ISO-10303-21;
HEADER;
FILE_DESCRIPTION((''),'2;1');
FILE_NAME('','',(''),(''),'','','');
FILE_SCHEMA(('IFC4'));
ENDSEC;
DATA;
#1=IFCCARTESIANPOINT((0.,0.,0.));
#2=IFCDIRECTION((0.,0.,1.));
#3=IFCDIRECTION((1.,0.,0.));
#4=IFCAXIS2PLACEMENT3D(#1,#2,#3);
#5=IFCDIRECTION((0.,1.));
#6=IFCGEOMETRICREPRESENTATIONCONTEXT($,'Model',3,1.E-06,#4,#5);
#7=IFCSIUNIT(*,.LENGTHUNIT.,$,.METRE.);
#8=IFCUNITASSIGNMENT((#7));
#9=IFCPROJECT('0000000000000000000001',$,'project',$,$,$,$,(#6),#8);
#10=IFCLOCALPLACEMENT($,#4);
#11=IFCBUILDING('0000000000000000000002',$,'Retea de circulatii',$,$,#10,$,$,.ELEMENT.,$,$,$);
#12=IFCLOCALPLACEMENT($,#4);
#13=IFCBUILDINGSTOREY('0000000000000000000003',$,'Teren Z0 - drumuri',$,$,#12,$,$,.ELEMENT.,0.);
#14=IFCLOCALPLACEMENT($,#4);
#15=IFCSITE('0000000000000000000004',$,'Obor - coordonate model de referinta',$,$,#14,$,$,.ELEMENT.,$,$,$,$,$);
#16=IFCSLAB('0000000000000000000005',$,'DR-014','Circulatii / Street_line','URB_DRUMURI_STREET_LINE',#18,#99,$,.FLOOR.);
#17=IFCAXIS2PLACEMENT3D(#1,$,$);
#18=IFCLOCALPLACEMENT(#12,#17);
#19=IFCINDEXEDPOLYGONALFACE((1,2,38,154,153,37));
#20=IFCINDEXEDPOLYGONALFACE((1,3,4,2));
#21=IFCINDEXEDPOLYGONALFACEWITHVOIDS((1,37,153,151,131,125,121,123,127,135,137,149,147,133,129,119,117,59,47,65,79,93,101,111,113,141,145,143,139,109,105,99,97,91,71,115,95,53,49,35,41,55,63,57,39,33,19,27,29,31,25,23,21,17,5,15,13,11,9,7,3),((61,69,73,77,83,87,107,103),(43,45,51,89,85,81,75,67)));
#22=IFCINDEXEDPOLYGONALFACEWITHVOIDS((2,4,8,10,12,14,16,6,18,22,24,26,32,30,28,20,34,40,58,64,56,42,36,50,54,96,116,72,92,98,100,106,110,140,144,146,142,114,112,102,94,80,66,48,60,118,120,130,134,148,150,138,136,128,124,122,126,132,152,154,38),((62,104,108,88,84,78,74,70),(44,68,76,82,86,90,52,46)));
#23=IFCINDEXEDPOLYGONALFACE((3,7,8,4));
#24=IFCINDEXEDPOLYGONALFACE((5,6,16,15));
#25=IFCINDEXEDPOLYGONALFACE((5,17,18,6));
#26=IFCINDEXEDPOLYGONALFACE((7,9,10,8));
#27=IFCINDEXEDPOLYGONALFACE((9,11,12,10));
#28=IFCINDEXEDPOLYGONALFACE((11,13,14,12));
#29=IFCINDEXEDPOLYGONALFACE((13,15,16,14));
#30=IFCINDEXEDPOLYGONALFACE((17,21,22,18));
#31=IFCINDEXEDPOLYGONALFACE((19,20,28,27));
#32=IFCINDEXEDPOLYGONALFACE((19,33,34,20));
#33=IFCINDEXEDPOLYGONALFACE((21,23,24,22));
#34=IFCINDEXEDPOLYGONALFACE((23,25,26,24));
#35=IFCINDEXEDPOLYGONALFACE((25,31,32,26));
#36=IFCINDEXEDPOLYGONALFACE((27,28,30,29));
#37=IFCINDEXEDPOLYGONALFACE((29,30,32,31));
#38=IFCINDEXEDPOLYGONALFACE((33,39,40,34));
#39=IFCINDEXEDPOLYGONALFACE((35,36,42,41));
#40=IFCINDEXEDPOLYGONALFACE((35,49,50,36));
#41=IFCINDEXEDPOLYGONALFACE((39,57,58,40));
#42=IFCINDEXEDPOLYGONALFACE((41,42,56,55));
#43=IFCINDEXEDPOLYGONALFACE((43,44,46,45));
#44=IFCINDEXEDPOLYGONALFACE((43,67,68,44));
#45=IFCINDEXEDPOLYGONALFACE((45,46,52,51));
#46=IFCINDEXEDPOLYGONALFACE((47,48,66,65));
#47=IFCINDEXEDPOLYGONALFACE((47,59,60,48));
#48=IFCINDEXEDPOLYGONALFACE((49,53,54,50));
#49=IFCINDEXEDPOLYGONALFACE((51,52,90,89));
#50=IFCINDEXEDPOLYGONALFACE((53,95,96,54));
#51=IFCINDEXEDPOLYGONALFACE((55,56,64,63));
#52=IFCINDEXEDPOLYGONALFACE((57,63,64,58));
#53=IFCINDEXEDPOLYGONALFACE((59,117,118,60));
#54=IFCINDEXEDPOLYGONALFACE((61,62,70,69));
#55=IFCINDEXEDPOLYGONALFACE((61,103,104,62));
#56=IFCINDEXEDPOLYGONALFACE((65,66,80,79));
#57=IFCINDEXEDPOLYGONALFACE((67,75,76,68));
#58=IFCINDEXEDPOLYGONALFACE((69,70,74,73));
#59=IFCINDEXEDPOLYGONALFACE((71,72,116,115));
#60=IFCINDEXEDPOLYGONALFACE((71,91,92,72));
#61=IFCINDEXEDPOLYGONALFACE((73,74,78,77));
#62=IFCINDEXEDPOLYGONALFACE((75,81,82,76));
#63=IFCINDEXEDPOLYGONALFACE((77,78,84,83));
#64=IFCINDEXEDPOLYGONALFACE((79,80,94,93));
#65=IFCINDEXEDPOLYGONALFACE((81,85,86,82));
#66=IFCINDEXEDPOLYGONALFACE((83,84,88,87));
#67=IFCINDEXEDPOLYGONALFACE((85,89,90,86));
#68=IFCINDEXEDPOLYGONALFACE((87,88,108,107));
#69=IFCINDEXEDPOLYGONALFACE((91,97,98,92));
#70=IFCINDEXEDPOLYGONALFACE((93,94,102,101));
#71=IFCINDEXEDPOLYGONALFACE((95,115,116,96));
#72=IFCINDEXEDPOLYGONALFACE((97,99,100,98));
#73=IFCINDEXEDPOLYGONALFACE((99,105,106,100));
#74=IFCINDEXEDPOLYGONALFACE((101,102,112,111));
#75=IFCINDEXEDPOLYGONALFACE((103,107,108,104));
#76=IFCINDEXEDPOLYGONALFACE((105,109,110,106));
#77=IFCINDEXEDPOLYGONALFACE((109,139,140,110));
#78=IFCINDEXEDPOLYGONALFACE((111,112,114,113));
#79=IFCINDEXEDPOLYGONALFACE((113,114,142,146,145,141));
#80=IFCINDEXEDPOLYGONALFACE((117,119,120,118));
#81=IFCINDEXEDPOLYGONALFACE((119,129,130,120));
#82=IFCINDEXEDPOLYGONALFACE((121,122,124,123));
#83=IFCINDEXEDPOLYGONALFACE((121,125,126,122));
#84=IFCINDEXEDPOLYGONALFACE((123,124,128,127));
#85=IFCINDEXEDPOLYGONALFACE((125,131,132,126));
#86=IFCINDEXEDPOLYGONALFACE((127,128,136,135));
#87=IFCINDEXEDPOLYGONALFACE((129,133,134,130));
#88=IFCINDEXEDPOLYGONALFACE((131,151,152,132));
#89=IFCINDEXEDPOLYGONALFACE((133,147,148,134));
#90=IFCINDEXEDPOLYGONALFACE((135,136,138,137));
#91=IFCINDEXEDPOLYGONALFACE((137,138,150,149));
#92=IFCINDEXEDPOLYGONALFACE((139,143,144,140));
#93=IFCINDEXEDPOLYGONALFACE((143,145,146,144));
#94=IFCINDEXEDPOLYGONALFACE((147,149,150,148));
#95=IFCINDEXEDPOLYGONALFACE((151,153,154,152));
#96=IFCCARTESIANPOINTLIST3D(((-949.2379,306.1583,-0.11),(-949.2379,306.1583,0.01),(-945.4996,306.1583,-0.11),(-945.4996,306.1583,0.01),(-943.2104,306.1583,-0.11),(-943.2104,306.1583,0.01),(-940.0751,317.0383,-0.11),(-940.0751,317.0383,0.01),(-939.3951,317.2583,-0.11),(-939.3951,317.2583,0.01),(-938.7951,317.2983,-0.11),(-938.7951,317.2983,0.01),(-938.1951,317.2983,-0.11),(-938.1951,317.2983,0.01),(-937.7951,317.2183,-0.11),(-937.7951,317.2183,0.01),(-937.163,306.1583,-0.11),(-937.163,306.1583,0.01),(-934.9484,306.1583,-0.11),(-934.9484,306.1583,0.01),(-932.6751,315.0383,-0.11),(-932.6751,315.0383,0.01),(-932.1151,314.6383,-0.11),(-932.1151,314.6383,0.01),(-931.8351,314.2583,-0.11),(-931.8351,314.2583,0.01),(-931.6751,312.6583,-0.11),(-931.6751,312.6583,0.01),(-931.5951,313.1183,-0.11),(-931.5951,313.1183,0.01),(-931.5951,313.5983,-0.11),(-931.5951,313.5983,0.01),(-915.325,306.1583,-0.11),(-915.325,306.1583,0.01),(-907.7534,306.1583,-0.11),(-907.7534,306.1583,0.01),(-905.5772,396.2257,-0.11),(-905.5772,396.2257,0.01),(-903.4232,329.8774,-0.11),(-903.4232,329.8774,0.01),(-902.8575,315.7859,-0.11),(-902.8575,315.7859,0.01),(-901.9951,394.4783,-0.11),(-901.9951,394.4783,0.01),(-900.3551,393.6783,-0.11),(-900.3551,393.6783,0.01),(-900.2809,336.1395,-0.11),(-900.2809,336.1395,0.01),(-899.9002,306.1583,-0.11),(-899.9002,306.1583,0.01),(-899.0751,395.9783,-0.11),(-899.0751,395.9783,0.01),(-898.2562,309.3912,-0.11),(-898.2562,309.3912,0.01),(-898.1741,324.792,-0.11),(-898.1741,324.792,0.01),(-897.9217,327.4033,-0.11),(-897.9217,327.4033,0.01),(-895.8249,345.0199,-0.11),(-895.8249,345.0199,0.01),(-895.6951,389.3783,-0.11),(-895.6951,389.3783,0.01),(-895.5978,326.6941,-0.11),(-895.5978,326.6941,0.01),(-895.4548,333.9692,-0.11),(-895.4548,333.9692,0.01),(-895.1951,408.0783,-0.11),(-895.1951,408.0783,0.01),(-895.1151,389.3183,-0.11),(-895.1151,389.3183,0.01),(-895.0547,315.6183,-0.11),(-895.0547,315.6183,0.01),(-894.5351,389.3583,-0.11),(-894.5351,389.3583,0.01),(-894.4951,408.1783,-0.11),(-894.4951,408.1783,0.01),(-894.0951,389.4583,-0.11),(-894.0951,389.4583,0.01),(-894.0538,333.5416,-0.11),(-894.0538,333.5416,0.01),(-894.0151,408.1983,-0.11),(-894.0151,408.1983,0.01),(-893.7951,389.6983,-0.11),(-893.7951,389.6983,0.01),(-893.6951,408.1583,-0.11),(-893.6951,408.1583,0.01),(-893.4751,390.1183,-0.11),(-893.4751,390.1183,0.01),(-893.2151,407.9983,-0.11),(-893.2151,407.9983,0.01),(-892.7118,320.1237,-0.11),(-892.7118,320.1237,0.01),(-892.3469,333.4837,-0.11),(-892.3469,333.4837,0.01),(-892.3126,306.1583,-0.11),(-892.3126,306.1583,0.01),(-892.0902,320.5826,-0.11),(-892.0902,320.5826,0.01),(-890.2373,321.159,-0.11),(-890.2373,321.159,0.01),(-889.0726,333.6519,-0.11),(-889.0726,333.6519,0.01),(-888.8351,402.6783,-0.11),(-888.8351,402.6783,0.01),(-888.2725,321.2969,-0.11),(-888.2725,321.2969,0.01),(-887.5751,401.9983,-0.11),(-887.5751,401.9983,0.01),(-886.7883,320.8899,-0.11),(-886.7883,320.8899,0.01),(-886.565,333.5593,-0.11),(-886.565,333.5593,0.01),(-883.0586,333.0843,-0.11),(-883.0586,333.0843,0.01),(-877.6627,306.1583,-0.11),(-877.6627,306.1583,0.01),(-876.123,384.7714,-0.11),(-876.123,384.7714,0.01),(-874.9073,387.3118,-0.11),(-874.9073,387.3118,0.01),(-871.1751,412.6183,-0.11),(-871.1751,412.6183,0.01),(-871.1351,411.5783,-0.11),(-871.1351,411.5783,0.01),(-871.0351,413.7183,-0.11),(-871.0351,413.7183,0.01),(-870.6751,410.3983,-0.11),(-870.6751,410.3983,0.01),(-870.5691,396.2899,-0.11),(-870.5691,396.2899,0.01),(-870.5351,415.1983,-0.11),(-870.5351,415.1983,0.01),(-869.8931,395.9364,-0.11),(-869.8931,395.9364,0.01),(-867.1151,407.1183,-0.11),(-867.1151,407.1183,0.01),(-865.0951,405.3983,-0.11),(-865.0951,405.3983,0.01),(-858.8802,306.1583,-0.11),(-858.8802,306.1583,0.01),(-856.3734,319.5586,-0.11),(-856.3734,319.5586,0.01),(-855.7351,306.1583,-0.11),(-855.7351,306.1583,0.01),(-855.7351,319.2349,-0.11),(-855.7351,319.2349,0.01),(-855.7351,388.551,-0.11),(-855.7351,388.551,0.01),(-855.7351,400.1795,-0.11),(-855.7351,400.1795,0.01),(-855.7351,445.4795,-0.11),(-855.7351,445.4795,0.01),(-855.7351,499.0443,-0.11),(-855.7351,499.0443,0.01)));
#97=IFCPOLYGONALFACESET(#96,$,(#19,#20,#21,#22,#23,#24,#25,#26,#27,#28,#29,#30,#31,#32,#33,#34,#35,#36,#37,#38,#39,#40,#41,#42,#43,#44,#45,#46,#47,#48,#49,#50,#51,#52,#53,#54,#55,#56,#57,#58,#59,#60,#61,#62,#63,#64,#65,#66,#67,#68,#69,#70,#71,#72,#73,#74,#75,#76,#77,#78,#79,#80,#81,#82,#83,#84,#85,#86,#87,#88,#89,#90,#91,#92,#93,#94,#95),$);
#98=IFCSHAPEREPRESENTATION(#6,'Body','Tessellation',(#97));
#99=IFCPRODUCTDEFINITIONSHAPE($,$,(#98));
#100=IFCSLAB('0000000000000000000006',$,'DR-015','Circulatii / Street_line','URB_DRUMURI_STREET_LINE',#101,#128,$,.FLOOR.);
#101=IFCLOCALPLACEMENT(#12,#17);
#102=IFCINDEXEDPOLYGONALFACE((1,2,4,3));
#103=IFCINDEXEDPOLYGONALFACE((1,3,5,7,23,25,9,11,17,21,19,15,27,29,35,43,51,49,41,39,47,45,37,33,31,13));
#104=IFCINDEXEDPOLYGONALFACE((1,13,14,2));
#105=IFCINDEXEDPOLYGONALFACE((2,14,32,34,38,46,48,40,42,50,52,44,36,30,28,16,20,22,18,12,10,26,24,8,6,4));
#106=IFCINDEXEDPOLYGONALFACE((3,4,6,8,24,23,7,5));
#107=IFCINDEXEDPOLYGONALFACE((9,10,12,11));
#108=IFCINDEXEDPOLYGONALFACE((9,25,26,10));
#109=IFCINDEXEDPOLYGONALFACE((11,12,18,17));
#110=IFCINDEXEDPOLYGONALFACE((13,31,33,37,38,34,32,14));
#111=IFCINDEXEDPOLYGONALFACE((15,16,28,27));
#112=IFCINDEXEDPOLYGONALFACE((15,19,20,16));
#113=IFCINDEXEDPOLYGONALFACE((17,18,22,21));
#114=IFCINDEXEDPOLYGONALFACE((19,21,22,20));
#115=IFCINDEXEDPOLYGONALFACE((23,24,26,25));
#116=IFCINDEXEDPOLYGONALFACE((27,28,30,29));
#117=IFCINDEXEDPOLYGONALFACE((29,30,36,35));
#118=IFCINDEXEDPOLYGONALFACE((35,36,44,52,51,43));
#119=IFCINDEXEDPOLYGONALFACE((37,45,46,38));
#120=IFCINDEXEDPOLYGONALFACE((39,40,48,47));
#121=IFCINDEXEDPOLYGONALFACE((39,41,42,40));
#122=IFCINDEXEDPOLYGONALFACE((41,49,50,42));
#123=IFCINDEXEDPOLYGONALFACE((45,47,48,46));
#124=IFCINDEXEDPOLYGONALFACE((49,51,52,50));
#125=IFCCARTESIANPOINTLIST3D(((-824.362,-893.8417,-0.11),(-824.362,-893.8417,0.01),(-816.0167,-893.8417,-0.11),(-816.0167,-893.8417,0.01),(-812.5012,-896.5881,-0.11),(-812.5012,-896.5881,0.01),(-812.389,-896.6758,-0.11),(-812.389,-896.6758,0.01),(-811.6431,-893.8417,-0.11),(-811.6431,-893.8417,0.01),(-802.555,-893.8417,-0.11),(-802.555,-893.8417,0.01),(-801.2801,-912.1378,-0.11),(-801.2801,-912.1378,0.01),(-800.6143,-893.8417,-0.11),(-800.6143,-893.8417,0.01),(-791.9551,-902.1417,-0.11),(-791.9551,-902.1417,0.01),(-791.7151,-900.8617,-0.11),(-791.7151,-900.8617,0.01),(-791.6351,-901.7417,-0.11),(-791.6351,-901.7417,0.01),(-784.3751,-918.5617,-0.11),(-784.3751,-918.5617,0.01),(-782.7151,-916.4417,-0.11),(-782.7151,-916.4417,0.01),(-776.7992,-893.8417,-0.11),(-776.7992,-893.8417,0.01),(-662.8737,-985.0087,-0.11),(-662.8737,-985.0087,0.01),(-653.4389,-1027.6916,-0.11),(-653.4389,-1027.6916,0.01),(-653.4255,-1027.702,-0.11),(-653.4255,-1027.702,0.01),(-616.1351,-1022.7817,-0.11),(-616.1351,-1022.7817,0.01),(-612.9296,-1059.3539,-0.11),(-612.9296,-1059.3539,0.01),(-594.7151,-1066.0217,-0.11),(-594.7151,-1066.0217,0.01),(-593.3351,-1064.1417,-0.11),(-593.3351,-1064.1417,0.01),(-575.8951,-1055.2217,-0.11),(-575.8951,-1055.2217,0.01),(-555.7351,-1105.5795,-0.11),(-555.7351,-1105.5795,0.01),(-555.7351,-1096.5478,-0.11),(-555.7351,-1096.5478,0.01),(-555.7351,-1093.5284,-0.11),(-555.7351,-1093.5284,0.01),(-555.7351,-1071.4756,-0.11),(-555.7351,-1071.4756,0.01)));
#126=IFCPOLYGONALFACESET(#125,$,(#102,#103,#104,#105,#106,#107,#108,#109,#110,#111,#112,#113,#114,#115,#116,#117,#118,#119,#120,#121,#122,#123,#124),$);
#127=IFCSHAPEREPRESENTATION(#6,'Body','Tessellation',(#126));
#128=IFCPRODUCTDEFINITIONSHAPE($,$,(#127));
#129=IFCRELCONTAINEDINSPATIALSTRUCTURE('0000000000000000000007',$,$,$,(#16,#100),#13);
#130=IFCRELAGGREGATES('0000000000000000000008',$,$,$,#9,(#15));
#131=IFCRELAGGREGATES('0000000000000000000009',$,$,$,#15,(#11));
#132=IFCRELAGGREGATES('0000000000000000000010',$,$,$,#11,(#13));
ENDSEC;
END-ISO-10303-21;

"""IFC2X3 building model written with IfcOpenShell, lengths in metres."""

from ifc_helpers import new_model, si_unit, direction, frame, origin_with_axes, place, context, project, spatial, polyline, outline, extrude, element, save


model = new_model("IFC2X3")

# Units and contexts
model_context = context("Model", 3, precision=1e-06, world=origin_with_axes(), true_north=direction((0.0, 1.0)))
ifc_project = project(units=[si_unit("LENGTHUNIT", "METRE")], contexts=[model_context])

# Site, building, storey
site_placement = place(None, origin_with_axes())
site = spatial("IfcSite", under=ifc_project, at=site_placement, Name="Obor - coordonate model de referinta", CompositionType="ELEMENT")
building_placement = place(None, origin_with_axes())
building = spatial("IfcBuilding", under=site, at=building_placement, Name="Retea de circulatii", CompositionType="ELEMENT")
storey_placement = place(None, origin_with_axes())
storey = spatial("IfcBuildingStorey", under=building, at=storey_placement, Name="Teren Z0 - drumuri", CompositionType="ELEMENT", Elevation=0.0)

# Slabs
slab_1_placement = place(None, origin_with_axes())
element("IfcSlab", 1, at=slab_1_placement, inside=storey, Name="DR-014", Description="Circulatii / Street_line", ObjectType="URB_DRUMURI_STREET_LINE", PredefinedType="FLOOR", context=model_context, shape_type="SweptSolid", body=[
    extrude(outline(polyline([(-949.2379, 306.1583), (-945.4996, 306.1583), (-940.0751, 317.0383), (-939.3951, 317.2583), (-938.7951, 317.2983), (-938.1951, 317.2983), (-937.7951, 317.2183), (-943.2104, 306.1583), (-937.163, 306.1583), (-932.6751, 315.0383), (-932.1151, 314.6383), (-931.8351, 314.2583), (-931.5951, 313.5983), (-931.5951, 313.1183), (-931.6751, 312.6583), (-934.9484, 306.1583), (-915.325, 306.1583), (-903.4232, 329.8774), (-897.9217, 327.4033), (-895.5978, 326.6941), (-898.1741, 324.792), (-902.8575, 315.7859), (-907.7534, 306.1583), (-899.9002, 306.1583), (-898.2562, 309.3912), (-892.3126, 306.1583), (-877.6627, 306.1583), (-895.0547, 315.6183), (-892.7118, 320.1237), (-892.0902, 320.5826), (-890.2373, 321.159), (-888.2725, 321.2969), (-886.7883, 320.8899), (-858.8802, 306.1583), (-855.7351, 306.1583), (-855.7351, 319.2349), (-856.3734, 319.5586), (-883.0586, 333.0843), (-886.565, 333.5593), (-889.0726, 333.6519), (-892.3469, 333.4837), (-894.0538, 333.5416), (-895.4548, 333.9692), (-900.2809, 336.1395), (-895.8249, 345.0199), (-876.123, 384.7714), (-874.9073, 387.3118), (-870.5691, 396.2899), (-869.8931, 395.9364), (-855.7351, 388.551), (-855.7351, 400.1795), (-865.0951, 405.3983), (-867.1151, 407.1183), (-870.6751, 410.3983), (-871.1351, 411.5783), (-871.1751, 412.6183), (-871.0351, 413.7183), (-870.5351, 415.1983), (-855.7351, 445.4795), (-855.7351, 499.0443), (-905.5772, 396.2257), (-949.2379, 306.1583)]), holes=[polyline([(-894.0951, 389.4583), (-894.5351, 389.3583), (-895.1151, 389.3183), (-895.6951, 389.3783), (-888.8351, 402.6783), (-887.5751, 401.9983), (-893.4751, 390.1183), (-893.7951, 389.6983), (-894.0951, 389.4583)]), polyline([(-895.1951, 408.0783), (-894.4951, 408.1783), (-894.0151, 408.1983), (-893.6951, 408.1583), (-893.2151, 407.9983), (-899.0751, 395.9783), (-900.3551, 393.6783), (-901.9951, 394.4783), (-895.1951, 408.0783)])]), frame((0.0, 0.0, -0.11), z_axis=(0.0, 0.0, 1.0), x_axis=(1.0, 0.0, 0.0)), (0.0, 0.0, 1.0), 0.12),
])
slab_2_placement = place(None, origin_with_axes())
element("IfcSlab", 2, at=slab_2_placement, inside=storey, Name="DR-015", Description="Circulatii / Street_line", ObjectType="URB_DRUMURI_STREET_LINE", PredefinedType="FLOOR", context=model_context, shape_type="SweptSolid", body=[
    extrude(outline(polyline([(-653.4389, -1027.6916), (-653.4255, -1027.702), (-612.9296, -1059.3539), (-555.7351, -1105.5795), (-555.7351, -1096.5478), (-594.7151, -1066.0217), (-593.3351, -1064.1417), (-555.7351, -1093.5284), (-555.7351, -1071.4756), (-575.8951, -1055.2217), (-616.1351, -1022.7817), (-662.8737, -985.0087), (-776.7992, -893.8417), (-800.6143, -893.8417), (-791.7151, -900.8617), (-791.6351, -901.7417), (-791.9551, -902.1417), (-802.555, -893.8417), (-811.6431, -893.8417), (-782.7151, -916.4417), (-784.3751, -918.5617), (-812.389, -896.6758), (-812.5012, -896.5881), (-816.0167, -893.8417), (-824.362, -893.8417), (-801.2801, -912.1378), (-653.4389, -1027.6916)])), frame((0.0, 0.0, -0.11), z_axis=(0.0, 0.0, 1.0), x_axis=(1.0, 0.0, 0.0)), (0.0, 0.0, 1.0), 0.12),
])

save(model, "model.ifc")
